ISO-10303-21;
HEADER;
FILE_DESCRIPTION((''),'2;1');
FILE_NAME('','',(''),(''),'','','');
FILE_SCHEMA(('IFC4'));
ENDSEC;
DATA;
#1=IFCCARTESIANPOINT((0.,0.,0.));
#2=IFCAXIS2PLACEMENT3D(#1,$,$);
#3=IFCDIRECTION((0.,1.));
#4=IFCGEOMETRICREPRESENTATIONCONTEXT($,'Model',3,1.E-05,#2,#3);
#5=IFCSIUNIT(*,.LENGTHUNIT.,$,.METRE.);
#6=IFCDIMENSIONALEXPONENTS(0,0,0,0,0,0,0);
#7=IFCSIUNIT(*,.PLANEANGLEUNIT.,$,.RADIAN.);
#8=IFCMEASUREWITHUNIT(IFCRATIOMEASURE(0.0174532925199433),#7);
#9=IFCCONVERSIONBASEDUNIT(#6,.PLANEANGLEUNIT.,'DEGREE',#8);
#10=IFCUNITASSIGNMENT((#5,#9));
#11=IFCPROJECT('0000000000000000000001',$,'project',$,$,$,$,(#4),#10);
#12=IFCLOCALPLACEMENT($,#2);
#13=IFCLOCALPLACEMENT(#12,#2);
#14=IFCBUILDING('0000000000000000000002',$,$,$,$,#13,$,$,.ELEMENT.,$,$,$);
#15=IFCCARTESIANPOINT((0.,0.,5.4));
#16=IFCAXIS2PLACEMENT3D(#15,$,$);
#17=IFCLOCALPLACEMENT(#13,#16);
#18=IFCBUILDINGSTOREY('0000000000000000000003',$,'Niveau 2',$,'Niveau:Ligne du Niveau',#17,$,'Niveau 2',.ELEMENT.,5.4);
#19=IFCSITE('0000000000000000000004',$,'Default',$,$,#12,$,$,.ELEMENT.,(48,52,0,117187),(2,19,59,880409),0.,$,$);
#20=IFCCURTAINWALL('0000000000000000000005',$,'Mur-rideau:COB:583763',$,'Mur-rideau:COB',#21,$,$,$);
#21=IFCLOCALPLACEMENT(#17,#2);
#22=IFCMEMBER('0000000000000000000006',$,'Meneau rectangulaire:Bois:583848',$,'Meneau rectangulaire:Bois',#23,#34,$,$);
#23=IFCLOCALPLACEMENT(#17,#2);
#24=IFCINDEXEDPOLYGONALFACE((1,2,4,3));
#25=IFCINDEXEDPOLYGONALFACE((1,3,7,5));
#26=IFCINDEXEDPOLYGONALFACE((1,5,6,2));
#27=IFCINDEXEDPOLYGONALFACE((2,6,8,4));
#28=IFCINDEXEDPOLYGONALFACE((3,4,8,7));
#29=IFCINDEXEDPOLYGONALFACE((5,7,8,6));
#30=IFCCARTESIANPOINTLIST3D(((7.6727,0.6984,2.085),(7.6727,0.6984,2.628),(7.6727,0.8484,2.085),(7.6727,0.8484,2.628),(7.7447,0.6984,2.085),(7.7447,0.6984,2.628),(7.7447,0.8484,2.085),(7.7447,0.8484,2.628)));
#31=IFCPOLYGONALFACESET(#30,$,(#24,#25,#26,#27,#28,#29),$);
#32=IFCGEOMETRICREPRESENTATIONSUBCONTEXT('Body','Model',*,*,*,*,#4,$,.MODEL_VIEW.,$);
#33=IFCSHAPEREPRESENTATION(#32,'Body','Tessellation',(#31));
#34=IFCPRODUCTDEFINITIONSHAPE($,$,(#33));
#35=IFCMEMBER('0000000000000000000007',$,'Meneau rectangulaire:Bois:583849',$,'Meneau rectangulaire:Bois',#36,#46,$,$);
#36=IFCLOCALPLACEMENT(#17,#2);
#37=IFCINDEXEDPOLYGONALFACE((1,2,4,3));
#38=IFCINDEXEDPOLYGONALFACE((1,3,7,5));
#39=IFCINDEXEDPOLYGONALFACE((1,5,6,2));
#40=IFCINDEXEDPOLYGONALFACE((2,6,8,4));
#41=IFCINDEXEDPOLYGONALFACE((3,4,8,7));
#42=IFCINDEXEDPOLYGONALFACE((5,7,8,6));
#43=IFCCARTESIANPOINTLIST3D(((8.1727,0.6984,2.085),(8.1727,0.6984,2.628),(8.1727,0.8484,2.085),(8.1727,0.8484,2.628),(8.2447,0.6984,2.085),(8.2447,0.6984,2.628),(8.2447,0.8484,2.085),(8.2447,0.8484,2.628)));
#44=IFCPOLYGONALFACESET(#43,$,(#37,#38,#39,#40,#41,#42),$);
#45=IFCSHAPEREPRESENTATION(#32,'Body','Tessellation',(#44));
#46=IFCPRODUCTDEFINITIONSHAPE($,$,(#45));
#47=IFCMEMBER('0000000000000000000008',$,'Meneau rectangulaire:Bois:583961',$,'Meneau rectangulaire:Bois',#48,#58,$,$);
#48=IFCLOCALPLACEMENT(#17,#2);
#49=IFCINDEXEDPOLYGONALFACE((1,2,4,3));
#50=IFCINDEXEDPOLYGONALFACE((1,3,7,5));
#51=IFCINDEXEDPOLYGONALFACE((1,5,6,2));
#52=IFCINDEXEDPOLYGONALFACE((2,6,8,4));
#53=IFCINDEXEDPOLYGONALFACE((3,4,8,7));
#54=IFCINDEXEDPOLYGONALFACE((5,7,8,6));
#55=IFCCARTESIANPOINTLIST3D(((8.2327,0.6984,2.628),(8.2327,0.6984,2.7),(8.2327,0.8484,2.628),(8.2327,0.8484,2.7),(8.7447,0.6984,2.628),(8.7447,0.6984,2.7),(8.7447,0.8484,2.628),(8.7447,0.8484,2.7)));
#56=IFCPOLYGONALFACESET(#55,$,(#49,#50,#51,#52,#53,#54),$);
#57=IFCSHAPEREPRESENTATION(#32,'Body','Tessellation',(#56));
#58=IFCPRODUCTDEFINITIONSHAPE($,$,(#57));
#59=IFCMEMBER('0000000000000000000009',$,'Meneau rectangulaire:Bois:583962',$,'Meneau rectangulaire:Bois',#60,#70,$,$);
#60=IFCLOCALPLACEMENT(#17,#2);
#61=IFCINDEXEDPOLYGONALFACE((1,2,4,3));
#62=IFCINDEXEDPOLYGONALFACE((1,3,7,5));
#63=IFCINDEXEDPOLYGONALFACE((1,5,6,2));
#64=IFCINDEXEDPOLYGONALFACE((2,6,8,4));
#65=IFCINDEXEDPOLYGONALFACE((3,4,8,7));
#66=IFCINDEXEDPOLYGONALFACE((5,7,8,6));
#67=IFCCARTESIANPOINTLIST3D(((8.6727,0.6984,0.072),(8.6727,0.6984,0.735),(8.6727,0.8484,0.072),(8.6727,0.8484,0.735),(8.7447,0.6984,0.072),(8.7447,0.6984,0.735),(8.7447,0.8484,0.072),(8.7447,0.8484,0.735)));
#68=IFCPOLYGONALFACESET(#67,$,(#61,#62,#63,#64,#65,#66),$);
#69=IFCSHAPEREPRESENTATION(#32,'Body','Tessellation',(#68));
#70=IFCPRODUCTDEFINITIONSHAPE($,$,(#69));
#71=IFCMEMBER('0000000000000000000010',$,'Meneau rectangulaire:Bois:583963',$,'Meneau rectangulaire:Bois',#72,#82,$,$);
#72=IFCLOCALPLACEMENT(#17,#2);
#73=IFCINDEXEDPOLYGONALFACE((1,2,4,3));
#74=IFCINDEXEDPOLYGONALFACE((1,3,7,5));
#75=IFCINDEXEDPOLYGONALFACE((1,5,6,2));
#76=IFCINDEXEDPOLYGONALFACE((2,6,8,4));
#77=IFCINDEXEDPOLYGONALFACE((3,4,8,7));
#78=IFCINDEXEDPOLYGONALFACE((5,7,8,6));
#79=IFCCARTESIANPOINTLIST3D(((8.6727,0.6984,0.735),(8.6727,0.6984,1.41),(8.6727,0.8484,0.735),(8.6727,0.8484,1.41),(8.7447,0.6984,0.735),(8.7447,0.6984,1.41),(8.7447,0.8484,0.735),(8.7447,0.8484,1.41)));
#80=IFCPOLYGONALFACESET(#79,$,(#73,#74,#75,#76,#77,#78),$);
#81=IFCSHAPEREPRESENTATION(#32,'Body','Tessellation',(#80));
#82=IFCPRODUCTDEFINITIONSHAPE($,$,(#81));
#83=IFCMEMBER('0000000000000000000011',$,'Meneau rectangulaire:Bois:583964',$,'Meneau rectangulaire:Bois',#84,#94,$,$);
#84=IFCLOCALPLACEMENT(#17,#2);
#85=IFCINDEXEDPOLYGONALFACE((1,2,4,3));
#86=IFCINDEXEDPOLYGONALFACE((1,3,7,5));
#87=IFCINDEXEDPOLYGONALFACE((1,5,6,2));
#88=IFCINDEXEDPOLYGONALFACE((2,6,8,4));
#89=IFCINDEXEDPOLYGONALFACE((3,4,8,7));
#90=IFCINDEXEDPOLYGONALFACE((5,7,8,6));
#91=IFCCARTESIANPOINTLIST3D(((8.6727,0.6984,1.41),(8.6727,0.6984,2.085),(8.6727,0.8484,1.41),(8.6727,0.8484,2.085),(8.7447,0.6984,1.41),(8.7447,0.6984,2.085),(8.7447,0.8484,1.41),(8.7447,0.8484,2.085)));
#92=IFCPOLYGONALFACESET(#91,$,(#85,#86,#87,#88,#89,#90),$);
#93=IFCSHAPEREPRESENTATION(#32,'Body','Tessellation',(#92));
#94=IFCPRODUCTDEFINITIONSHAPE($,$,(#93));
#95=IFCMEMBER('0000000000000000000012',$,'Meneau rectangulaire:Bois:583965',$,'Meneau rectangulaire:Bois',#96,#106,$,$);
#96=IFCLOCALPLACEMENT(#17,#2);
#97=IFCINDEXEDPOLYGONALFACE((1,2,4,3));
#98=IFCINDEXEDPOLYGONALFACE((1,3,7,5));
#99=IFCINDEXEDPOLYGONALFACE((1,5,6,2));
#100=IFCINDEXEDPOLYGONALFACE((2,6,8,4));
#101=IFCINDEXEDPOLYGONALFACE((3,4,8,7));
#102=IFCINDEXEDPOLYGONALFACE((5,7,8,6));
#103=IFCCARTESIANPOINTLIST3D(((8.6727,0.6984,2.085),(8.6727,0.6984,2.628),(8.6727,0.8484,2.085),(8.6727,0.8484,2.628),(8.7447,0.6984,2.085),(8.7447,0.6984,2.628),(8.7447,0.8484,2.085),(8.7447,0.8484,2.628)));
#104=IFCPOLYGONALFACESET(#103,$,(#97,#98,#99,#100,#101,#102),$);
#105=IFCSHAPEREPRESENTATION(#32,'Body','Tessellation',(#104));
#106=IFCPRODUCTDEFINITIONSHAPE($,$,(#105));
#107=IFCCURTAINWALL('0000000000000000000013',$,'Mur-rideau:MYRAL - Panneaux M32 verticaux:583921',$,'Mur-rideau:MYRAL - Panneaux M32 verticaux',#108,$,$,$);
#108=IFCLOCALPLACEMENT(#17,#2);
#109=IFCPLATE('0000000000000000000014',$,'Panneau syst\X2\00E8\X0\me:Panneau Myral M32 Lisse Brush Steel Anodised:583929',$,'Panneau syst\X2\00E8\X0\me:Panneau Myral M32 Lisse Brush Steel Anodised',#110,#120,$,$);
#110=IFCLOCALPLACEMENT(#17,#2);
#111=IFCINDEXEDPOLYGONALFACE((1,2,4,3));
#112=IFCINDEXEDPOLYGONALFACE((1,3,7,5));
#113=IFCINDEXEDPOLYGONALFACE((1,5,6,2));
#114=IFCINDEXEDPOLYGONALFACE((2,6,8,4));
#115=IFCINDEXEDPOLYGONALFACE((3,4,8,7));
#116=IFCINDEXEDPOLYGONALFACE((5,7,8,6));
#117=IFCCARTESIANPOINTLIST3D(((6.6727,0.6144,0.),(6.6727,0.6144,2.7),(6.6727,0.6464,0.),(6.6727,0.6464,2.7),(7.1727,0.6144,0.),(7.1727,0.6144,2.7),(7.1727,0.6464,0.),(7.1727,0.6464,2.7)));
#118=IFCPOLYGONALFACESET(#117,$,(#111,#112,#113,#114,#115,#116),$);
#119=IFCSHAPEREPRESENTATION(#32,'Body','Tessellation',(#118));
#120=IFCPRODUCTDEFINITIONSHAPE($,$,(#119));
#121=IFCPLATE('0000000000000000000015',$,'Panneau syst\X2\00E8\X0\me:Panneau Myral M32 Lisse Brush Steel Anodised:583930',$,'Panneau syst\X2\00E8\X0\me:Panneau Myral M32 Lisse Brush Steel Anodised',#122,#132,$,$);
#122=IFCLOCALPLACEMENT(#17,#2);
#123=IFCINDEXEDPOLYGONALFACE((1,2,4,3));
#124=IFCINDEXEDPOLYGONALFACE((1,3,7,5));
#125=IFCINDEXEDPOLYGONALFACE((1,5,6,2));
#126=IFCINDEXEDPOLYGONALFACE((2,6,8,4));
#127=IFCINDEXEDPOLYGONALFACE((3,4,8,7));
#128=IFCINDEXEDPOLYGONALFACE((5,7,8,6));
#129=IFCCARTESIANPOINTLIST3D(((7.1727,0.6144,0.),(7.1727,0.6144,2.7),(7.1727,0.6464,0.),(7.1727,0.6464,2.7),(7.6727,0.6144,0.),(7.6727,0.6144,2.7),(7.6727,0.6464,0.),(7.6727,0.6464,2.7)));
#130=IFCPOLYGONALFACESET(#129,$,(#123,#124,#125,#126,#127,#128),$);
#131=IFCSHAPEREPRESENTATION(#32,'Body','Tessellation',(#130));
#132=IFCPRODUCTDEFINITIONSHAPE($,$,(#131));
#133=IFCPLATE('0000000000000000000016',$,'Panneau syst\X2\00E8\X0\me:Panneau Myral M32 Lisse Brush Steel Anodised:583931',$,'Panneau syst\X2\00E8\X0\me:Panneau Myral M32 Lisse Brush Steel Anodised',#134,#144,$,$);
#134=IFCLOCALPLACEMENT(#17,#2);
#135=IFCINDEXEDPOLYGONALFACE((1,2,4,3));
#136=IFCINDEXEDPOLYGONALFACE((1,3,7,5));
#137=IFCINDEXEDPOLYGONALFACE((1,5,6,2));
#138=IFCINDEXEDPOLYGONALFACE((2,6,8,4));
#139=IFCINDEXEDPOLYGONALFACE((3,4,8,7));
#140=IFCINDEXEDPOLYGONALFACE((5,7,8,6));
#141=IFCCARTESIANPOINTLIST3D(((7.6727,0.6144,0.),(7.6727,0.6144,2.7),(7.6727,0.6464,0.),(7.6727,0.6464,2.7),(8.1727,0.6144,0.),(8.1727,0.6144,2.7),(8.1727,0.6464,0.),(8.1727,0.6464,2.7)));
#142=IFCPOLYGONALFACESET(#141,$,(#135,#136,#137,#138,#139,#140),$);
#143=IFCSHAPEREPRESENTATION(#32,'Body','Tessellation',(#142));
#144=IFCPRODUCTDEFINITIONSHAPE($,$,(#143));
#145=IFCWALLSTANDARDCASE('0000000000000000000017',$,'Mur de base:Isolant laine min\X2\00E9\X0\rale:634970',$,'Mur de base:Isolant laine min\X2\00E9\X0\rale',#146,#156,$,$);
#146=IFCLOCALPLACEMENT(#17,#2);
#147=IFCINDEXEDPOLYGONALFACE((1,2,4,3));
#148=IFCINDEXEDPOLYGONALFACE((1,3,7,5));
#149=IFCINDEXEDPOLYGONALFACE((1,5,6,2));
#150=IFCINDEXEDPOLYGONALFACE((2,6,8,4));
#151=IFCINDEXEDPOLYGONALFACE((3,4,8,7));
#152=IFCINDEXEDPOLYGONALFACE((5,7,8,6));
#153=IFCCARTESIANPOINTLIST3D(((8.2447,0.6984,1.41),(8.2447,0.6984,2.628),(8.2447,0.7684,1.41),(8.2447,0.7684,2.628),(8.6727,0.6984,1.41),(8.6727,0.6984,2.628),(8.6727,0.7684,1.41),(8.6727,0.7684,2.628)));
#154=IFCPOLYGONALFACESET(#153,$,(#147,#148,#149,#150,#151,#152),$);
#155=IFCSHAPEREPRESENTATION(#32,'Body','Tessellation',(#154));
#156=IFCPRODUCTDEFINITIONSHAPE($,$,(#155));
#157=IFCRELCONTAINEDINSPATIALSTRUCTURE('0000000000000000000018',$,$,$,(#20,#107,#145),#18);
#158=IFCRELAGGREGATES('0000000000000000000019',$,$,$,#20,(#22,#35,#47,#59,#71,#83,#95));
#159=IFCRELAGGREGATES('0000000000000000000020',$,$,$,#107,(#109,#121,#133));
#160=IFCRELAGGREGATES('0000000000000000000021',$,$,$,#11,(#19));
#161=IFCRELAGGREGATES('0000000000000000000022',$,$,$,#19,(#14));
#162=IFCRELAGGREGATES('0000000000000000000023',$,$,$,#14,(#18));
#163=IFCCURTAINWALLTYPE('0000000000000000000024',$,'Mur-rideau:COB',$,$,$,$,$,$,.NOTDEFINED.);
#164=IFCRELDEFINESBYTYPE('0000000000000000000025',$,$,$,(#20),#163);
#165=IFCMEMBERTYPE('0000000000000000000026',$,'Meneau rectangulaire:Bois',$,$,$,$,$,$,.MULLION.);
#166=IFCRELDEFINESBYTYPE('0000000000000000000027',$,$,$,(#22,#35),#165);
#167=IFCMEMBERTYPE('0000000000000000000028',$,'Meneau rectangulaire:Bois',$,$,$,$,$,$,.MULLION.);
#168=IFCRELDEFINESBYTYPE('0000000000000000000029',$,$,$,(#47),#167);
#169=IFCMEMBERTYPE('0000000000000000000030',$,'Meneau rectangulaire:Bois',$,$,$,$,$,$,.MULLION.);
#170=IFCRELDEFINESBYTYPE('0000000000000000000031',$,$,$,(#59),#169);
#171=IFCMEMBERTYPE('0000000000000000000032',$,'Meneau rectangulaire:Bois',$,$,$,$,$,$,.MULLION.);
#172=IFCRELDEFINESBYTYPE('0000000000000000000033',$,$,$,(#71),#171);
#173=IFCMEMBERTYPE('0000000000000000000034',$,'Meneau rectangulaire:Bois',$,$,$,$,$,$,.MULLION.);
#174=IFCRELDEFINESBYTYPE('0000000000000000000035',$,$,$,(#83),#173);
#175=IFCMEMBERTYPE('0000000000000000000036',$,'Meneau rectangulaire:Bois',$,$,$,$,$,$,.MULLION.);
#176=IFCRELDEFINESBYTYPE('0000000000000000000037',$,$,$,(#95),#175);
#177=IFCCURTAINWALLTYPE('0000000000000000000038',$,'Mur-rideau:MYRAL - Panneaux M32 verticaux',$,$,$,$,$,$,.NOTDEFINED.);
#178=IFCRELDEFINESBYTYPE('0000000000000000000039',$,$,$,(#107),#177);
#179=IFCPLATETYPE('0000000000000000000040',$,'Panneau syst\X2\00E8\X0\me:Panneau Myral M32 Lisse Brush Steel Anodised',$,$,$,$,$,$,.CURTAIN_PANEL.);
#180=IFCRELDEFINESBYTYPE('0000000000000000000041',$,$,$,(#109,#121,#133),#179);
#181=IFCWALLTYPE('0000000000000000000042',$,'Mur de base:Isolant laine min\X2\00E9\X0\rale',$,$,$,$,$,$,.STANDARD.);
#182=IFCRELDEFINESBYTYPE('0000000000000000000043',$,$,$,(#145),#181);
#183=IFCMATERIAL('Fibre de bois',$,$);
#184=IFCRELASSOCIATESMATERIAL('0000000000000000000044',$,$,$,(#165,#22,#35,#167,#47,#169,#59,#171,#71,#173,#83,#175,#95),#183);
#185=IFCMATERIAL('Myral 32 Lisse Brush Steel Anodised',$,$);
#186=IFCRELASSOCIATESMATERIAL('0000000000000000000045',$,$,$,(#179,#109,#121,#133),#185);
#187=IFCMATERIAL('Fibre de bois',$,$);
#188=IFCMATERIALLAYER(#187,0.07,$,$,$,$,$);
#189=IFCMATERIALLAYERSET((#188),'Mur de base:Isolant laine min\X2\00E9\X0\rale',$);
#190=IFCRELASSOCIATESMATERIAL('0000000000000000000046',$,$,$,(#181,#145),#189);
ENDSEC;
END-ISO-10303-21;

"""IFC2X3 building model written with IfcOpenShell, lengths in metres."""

from ifc_helpers import new_model, entity, si_unit, converted_unit, direction, frame, frame_2d, origin, origin_2d_with_axis, place, context, subcontext, project, spatial, rectangle, extrude, source, transform, mapped, material, layer, layer_set, layer_usage, type_object, type_shapes, element, aggregate, save


model = new_model("IFC2X3")

# Units and contexts
model_context = context("Model", 3, precision=1e-05, world=origin(), true_north=direction((0.0, 1.0)))
body_context = subcontext(model_context, "Body", "Model", "MODEL_VIEW")
ifc_project = project(units=[si_unit("LENGTHUNIT", "METRE"), converted_unit("PLANEANGLEUNIT", "DEGREE", entity("IfcRatioMeasure", 0.0174532925199433), si_unit("PLANEANGLEUNIT", "RADIAN"), dimensions=[0, 0, 0, 0, 0, 0, 0])], contexts=[model_context])

# Site, building, storey
site_placement = place(None, origin())
site = spatial("IfcSite", under=ifc_project, at=site_placement, Name="Default", CompositionType="ELEMENT", RefLatitude=(48, 52, 0, 117187), RefLongitude=(2, 19, 59, 880409), RefElevation=0.0)
building_placement = place(site_placement, origin())
building = spatial("IfcBuilding", under=site, at=building_placement, CompositionType="ELEMENT")
storey_placement = place(building_placement, frame((0.0, 0.0, 5.4)))
storey = spatial("IfcBuildingStorey", under=building, at=storey_placement, Name="Niveau 2", ObjectType="Niveau:Ligne du Niveau", LongName="Niveau 2", CompositionType="ELEMENT", Elevation=5.4)

# Curtain wall, members
curtain_wall_type_1 = type_object("IfcCurtainWallType", Name="Mur-rideau:COB", PredefinedType="NOTDEFINED")
curtain_wall_1_placement = place(storey_placement, frame((0.0, 0.0, -5.4)))
curtain_wall_1 = element("IfcCurtainWall", 1, at=curtain_wall_1_placement, inside=storey, type_object=curtain_wall_type_1, Name="Mur-rideau:COB:583763", ObjectType="Mur-rideau:COB")
ifc_material_1 = material(Name="Fibre de bois")
member_type_1 = type_object("IfcMemberType", Name="Meneau rectangulaire:Bois", PredefinedType="MULLION", material=ifc_material_1)
shared_shape_1 = source(origin(), body_context, "Body", "SweptSolid", [
    extrude(rectangle(XDim=0.15, YDim=0.072, at=origin_2d_with_axis()), frame((-0.024, 0.0, -0.543), z_axis=(0.0, 0.0, 1.0), x_axis=(0.0, -1.0, 0.0)), (0.0, 0.0, 1.0), 0.543),
])
type_shapes(member_type_1, [shared_shape_1])
member_1_placement = place(storey_placement, frame((7.7327, 0.7734, 2.085), z_axis=(0.0, 0.0, -1.0), x_axis=(1.0, 0.0, 0.0)))
member_1 = element("IfcMember", 2, at=member_1_placement, type_object=member_type_1, material=ifc_material_1, Name="Meneau rectangulaire:Bois:583848", ObjectType="Meneau rectangulaire:Bois", context=body_context, shape_type="MappedRepresentation", body=[
    mapped(shared_shape_1, transform((0.0, 0.0, 0.0), scale=1.0)),
])
member_2_placement = place(storey_placement, frame((8.2327, 0.7734, 2.085), z_axis=(0.0, 0.0, -1.0), x_axis=(1.0, 0.0, 0.0)))
member_2 = element("IfcMember", 3, at=member_2_placement, type_object=member_type_1, material=ifc_material_1, Name="Meneau rectangulaire:Bois:583849", ObjectType="Meneau rectangulaire:Bois", context=body_context, shape_type="MappedRepresentation", body=[
    mapped(shared_shape_1, transform((0.0, 0.0, 0.0), scale=1.0)),
])
member_type_2 = type_object("IfcMemberType", Name="Meneau rectangulaire:Bois", PredefinedType="MULLION", material=ifc_material_1)
shared_shape_2 = source(origin(), body_context, "Body", "SweptSolid", [
    extrude(rectangle(XDim=0.15, YDim=0.072, at=origin_2d_with_axis()), frame((-0.036, 0.0, -0.512), z_axis=(0.0, 0.0, 1.0), x_axis=(0.0, -1.0, 0.0)), (0.0, 0.0, 1.0), 0.512),
])
type_shapes(member_type_2, [shared_shape_2])
member_3_placement = place(storey_placement, frame((8.7447, 0.7734, 2.7), z_axis=(1.0, 0.0, 0.0), x_axis=(0.0, 0.0, 1.0)))
member_3 = element("IfcMember", 4, at=member_3_placement, type_object=member_type_2, material=ifc_material_1, Name="Meneau rectangulaire:Bois:583961", ObjectType="Meneau rectangulaire:Bois", context=body_context, shape_type="MappedRepresentation", body=[
    mapped(shared_shape_2, transform((0.0, 0.0, 0.0), scale=1.0)),
])
member_type_3 = type_object("IfcMemberType", Name="Meneau rectangulaire:Bois", PredefinedType="MULLION", material=ifc_material_1)
shared_shape_3 = source(origin(), body_context, "Body", "SweptSolid", [
    extrude(rectangle(XDim=0.15, YDim=0.072, at=origin_2d_with_axis()), frame((-0.024, 0.0, -0.663), z_axis=(0.0, 0.0, 1.0), x_axis=(0.0, -1.0, 0.0)), (0.0, 0.0, 1.0), 0.663),
])
type_shapes(member_type_3, [shared_shape_3])
member_4_placement = place(storey_placement, frame((8.7327, 0.7734, 0.072), z_axis=(0.0, 0.0, -1.0), x_axis=(1.0, 0.0, 0.0)))
member_4 = element("IfcMember", 5, at=member_4_placement, type_object=member_type_3, material=ifc_material_1, Name="Meneau rectangulaire:Bois:583962", ObjectType="Meneau rectangulaire:Bois", context=body_context, shape_type="MappedRepresentation", body=[
    mapped(shared_shape_3, transform((0.0, 0.0, 0.0), scale=1.0)),
])
member_type_4 = type_object("IfcMemberType", Name="Meneau rectangulaire:Bois", PredefinedType="MULLION", material=ifc_material_1)
shared_shape_4 = source(origin(), body_context, "Body", "SweptSolid", [
    extrude(rectangle(XDim=0.15, YDim=0.072, at=origin_2d_with_axis()), frame((-0.024, 0.0, -0.675), z_axis=(0.0, 0.0, 1.0), x_axis=(0.0, -1.0, 0.0)), (0.0, 0.0, 1.0), 0.675),
])
type_shapes(member_type_4, [shared_shape_4])
member_5_placement = place(storey_placement, frame((8.7327, 0.7734, 0.735), z_axis=(0.0, 0.0, -1.0), x_axis=(1.0, 0.0, 0.0)))
member_5 = element("IfcMember", 6, at=member_5_placement, type_object=member_type_4, material=ifc_material_1, Name="Meneau rectangulaire:Bois:583963", ObjectType="Meneau rectangulaire:Bois", context=body_context, shape_type="MappedRepresentation", body=[
    mapped(shared_shape_4, transform((0.0, 0.0, 0.0), scale=1.0)),
])
member_type_5 = type_object("IfcMemberType", Name="Meneau rectangulaire:Bois", PredefinedType="MULLION", material=ifc_material_1)
shared_shape_5 = source(origin(), body_context, "Body", "SweptSolid", [
    extrude(rectangle(XDim=0.15, YDim=0.072, at=origin_2d_with_axis()), frame((-0.024, 0.0, -0.675), z_axis=(0.0, 0.0, 1.0), x_axis=(0.0, -1.0, 0.0)), (0.0, 0.0, 1.0), 0.675),
])
type_shapes(member_type_5, [shared_shape_5])
member_6_placement = place(storey_placement, frame((8.7327, 0.7734, 1.41), z_axis=(0.0, 0.0, -1.0), x_axis=(1.0, 0.0, 0.0)))
member_6 = element("IfcMember", 7, at=member_6_placement, type_object=member_type_5, material=ifc_material_1, Name="Meneau rectangulaire:Bois:583964", ObjectType="Meneau rectangulaire:Bois", context=body_context, shape_type="MappedRepresentation", body=[
    mapped(shared_shape_5, transform((0.0, 0.0, 0.0), scale=1.0)),
])
member_type_6 = type_object("IfcMemberType", Name="Meneau rectangulaire:Bois", PredefinedType="MULLION", material=ifc_material_1)
shared_shape_6 = source(origin(), body_context, "Body", "SweptSolid", [
    extrude(rectangle(XDim=0.15, YDim=0.072, at=origin_2d_with_axis()), frame((-0.024, 0.0, -0.543), z_axis=(0.0, 0.0, 1.0), x_axis=(0.0, -1.0, 0.0)), (0.0, 0.0, 1.0), 0.543),
])
type_shapes(member_type_6, [shared_shape_6])
member_7_placement = place(storey_placement, frame((8.7327, 0.7734, 2.085), z_axis=(0.0, 0.0, -1.0), x_axis=(1.0, 0.0, 0.0)))
member_7 = element("IfcMember", 8, at=member_7_placement, type_object=member_type_6, material=ifc_material_1, Name="Meneau rectangulaire:Bois:583965", ObjectType="Meneau rectangulaire:Bois", context=body_context, shape_type="MappedRepresentation", body=[
    mapped(shared_shape_6, transform((0.0, 0.0, 0.0), scale=1.0)),
])
aggregate(curtain_wall_1, [member_1, member_2, member_3, member_4, member_5, member_6, member_7])

# Curtain wall, plates
curtain_wall_type_2 = type_object("IfcCurtainWallType", Name="Mur-rideau:MYRAL - Panneaux M32 verticaux", PredefinedType="NOTDEFINED")
curtain_wall_2_placement = place(storey_placement, frame((0.0, 0.0, -5.4)))
curtain_wall_2 = element("IfcCurtainWall", 9, at=curtain_wall_2_placement, inside=storey, type_object=curtain_wall_type_2, Name="Mur-rideau:MYRAL - Panneaux M32 verticaux:583921", ObjectType="Mur-rideau:MYRAL - Panneaux M32 verticaux")
ifc_material_2 = material(Name="Myral 32 Lisse Brush Steel Anodised")
plate_type = type_object("IfcPlateType", Name="Panneau système:Panneau Myral M32 Lisse Brush Steel Anodised", PredefinedType="CURTAIN_PANEL", material=ifc_material_2)
shared_shape_7 = source(origin(), body_context, "Body", "SweptSolid", [
    extrude(rectangle(XDim=0.032, YDim=0.5, at=origin_2d_with_axis()), frame((0.0, -0.016, 0.0), z_axis=(0.0, 0.0, 1.0), x_axis=(0.0, 1.0, 0.0)), (0.0, 0.0, 1.0), 2.7),
])
type_shapes(plate_type, [shared_shape_7])
plate_1_placement = place(curtain_wall_2_placement, frame((6.9227, 0.6464, 5.4)))
plate_1 = element("IfcPlate", 10, at=plate_1_placement, type_object=plate_type, material=ifc_material_2, Name="Panneau système:Panneau Myral M32 Lisse Brush Steel Anodised:583929", ObjectType="Panneau système:Panneau Myral M32 Lisse Brush Steel Anodised", context=body_context, shape_type="MappedRepresentation", body=[
    mapped(shared_shape_7, transform((0.0, 0.0, 0.0), scale=1.0)),
])
plate_2_placement = place(curtain_wall_2_placement, frame((7.4227, 0.6464, 5.4)))
plate_2 = element("IfcPlate", 11, at=plate_2_placement, type_object=plate_type, material=ifc_material_2, Name="Panneau système:Panneau Myral M32 Lisse Brush Steel Anodised:583930", ObjectType="Panneau système:Panneau Myral M32 Lisse Brush Steel Anodised", context=body_context, shape_type="MappedRepresentation", body=[
    mapped(shared_shape_7, transform((0.0, 0.0, 0.0), scale=1.0)),
])
plate_3_placement = place(curtain_wall_2_placement, frame((7.9227, 0.6464, 5.4)))
plate_3 = element("IfcPlate", 12, at=plate_3_placement, type_object=plate_type, material=ifc_material_2, Name="Panneau système:Panneau Myral M32 Lisse Brush Steel Anodised:583931", ObjectType="Panneau système:Panneau Myral M32 Lisse Brush Steel Anodised", context=body_context, shape_type="MappedRepresentation", body=[
    mapped(shared_shape_7, transform((0.0, 0.0, 0.0), scale=1.0)),
])
aggregate(curtain_wall_2, [plate_1, plate_2, plate_3])

# Wall
ifc_material_3 = material(Name="Fibre de bois")
ifc_layer = layer(ifc_material_3, 0.07)
ifc_layer_set = layer_set([ifc_layer], Name="Mur de base:Isolant laine minérale")
ifc_layer_usage = layer_usage(ifc_layer_set, "AXIS2", "NEGATIVE", 0.035)
wall_type = type_object("IfcWallType", Name="Mur de base:Isolant laine minérale", PredefinedType="STANDARD", material=ifc_layer_set)
wall_placement = place(storey_placement, frame((8.2447, 0.7334, 1.41)))
element("IfcWallStandardCase", 13, at=wall_placement, inside=storey, type_object=wall_type, material=ifc_layer_usage, Name="Mur de base:Isolant laine minérale:634970", ObjectType="Mur de base:Isolant laine minérale", context=body_context, shape_type="SweptSolid", body=[
    extrude(rectangle(XDim=0.428, YDim=0.07, at=frame_2d((0.214, 0.0), x_axis=(-1.0, 0.0))), origin(), (0.0, 0.0, 1.0), 1.218),
])

save(model, "model.ifc")
